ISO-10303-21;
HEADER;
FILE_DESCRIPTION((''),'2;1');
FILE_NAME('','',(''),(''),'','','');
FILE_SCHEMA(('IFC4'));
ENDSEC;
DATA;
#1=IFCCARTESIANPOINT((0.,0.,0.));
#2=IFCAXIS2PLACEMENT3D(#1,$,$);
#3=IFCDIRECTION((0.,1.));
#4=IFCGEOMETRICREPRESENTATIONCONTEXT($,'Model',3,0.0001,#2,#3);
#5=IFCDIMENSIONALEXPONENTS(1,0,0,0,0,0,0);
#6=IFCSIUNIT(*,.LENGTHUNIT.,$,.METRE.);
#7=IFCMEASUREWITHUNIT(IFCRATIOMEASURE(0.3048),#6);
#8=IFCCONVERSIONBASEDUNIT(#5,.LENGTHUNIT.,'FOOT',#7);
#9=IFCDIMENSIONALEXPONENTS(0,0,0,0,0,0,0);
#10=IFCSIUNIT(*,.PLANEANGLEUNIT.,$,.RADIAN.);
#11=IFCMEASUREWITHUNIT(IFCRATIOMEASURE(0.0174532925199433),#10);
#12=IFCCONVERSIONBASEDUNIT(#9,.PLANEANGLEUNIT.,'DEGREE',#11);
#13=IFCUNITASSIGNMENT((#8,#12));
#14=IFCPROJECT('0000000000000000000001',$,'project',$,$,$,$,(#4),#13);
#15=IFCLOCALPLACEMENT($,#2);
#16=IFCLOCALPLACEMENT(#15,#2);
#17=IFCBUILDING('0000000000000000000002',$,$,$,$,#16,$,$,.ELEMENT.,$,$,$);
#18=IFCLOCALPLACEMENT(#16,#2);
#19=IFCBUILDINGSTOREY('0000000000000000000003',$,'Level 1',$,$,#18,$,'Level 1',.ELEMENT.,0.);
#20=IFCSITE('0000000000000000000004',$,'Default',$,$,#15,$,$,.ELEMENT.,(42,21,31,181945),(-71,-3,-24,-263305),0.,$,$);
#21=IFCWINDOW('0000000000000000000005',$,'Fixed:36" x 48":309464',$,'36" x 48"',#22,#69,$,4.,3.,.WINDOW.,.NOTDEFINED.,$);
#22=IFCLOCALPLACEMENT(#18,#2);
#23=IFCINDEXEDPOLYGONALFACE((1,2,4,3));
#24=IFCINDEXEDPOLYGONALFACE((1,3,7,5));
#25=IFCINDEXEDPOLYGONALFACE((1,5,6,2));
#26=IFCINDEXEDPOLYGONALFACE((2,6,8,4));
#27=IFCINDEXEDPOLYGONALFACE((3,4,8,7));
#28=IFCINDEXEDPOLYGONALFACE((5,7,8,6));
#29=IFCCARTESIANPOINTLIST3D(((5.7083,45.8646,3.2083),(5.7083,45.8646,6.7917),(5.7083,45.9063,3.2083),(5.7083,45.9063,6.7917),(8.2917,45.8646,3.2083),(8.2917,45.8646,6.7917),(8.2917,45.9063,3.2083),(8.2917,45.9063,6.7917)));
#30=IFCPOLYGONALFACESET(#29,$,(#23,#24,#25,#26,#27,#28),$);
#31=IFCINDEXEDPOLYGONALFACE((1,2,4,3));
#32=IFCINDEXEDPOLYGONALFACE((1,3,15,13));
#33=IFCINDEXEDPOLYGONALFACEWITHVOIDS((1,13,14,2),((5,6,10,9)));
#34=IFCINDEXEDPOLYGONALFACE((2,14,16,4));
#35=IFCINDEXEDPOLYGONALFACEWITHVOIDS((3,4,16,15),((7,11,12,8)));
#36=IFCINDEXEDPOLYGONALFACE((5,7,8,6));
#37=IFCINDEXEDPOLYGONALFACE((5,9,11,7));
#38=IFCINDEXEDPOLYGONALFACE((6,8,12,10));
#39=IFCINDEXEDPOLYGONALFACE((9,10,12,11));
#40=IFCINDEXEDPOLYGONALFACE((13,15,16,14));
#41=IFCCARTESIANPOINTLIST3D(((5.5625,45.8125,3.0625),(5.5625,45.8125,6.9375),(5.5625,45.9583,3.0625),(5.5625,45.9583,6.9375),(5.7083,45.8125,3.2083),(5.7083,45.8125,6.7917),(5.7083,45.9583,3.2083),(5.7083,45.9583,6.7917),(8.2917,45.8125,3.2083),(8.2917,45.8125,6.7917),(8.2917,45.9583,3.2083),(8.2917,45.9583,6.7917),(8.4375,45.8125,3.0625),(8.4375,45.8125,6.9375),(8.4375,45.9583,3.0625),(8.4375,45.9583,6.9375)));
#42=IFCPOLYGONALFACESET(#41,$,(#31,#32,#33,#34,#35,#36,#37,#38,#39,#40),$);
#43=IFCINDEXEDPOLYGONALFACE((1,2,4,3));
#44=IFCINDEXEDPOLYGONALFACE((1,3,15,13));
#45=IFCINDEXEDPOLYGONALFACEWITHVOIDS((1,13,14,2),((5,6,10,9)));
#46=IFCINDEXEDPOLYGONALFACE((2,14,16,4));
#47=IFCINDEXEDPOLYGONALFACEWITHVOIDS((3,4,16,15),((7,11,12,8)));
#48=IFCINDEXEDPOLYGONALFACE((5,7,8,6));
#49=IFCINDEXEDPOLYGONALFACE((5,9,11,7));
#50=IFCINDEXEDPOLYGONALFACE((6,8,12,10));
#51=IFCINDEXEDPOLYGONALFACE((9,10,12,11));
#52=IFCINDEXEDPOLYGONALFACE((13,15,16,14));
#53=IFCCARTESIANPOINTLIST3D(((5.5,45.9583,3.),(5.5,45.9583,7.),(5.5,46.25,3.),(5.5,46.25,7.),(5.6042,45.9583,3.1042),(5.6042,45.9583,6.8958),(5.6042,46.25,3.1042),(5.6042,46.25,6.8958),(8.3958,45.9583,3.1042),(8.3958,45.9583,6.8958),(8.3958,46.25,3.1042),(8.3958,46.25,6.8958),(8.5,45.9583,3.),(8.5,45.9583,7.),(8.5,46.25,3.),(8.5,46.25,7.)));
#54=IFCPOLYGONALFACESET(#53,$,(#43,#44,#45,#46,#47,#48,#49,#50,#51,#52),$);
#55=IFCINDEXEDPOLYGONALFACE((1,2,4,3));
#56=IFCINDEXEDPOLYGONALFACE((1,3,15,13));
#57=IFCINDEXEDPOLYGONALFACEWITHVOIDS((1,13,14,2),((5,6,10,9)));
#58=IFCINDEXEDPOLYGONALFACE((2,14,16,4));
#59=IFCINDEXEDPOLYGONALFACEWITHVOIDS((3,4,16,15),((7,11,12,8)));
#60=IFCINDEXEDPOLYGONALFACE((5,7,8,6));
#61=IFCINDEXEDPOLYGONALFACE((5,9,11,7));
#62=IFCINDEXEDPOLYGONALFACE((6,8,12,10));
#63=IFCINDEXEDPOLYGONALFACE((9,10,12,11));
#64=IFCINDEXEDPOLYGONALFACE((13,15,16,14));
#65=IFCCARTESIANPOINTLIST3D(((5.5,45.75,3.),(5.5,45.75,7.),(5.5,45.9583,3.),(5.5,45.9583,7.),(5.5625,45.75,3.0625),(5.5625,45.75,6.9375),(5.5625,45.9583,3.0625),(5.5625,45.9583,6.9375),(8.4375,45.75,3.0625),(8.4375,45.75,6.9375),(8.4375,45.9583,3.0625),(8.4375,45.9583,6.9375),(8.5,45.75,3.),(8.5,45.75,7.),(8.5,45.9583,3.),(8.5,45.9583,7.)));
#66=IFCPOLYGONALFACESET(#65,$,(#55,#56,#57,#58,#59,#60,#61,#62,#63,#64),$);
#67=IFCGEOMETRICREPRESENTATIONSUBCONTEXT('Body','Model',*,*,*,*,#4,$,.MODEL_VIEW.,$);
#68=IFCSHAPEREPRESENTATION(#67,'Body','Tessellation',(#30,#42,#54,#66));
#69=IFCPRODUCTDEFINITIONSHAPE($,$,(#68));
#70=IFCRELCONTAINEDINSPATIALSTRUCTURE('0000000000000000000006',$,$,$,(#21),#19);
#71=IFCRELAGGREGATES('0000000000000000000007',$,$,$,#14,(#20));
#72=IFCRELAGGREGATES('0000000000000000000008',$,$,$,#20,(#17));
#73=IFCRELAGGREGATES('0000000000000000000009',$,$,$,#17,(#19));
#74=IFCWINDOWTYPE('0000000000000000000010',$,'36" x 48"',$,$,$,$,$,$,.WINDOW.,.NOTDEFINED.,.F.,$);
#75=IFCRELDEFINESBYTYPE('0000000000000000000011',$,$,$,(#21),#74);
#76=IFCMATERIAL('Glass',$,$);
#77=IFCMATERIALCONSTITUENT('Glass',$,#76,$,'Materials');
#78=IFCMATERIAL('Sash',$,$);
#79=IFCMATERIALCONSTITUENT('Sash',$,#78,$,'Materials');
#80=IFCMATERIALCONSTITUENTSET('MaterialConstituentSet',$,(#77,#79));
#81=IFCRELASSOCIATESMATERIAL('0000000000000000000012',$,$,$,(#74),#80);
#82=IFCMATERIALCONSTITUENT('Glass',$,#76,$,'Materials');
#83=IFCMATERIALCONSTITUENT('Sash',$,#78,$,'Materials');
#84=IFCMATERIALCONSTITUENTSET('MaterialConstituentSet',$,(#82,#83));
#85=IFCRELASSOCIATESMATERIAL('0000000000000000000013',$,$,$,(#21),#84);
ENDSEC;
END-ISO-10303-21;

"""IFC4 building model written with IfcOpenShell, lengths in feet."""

from ifc_helpers import new_model, entity, si_unit, converted_unit, direction, frame, frame_2d, origin, place, context, subcontext, project, spatial, polyline, rectangle, outline, extrude, source, transform, mapped, material, constituent, constituent_set, type_object, type_shapes, element, save


model = new_model("IFC4")

# Units and contexts
model_context = context("Model", 3, precision=0.0001, world=origin(), true_north=direction((0.0, 1.0)))
body_context = subcontext(model_context, "Body", "Model", "MODEL_VIEW")
ifc_project = project(units=[converted_unit("LENGTHUNIT", "FOOT", entity("IfcRatioMeasure", 0.3048), si_unit("LENGTHUNIT", "METRE"), dimensions=[1, 0, 0, 0, 0, 0, 0]), converted_unit("PLANEANGLEUNIT", "DEGREE", entity("IfcRatioMeasure", 0.0174532925199433), si_unit("PLANEANGLEUNIT", "RADIAN"), dimensions=[0, 0, 0, 0, 0, 0, 0])], contexts=[model_context])

# Site, building, storey
site_placement = place(None, origin())
site = spatial("IfcSite", under=ifc_project, at=site_placement, Name="Default", CompositionType="ELEMENT", RefLatitude=(42, 21, 31, 181945), RefLongitude=(-71, -3, -24, -263305), RefElevation=0.0)
building_placement = place(site_placement, origin())
building = spatial("IfcBuilding", under=site, at=building_placement, CompositionType="ELEMENT")
storey_placement = place(building_placement, origin())
storey = spatial("IfcBuildingStorey", under=building, at=storey_placement, Name="Level 1", LongName="Level 1", CompositionType="ELEMENT", Elevation=0.0)

# Shared definitions
placement_1 = place(storey_placement, frame((-0.25, 46.0, 0.0)))

# Window
ifc_material_1 = material(Name="Glass")
ifc_constituent_1 = constituent(ifc_material_1, Name="Glass", Category="Materials")
ifc_material_2 = material(Name="Sash")
ifc_constituent_2 = constituent(ifc_material_2, Name="Sash", Category="Materials")
ifc_constituent_set_1 = constituent_set(constituents=[ifc_constituent_1, ifc_constituent_2], Name="MaterialConstituentSet")
ifc_constituent_3 = constituent(ifc_material_1, Name="Glass", Category="Materials")
ifc_constituent_4 = constituent(ifc_material_2, Name="Sash", Category="Materials")
ifc_constituent_set_2 = constituent_set(constituents=[ifc_constituent_3, ifc_constituent_4], Name="MaterialConstituentSet")
window_type = type_object("IfcWindowType", Name="36\" x 48\"", ParameterTakesPrecedence=False, PartitioningType="NOTDEFINED", PredefinedType="WINDOW", material=ifc_constituent_set_2)
shared_shape = source(origin(), body_context, "Body", "SweptSolid", [
    extrude(rectangle(XDim=0.0417, YDim=2.5833, at=frame_2d((0.0, 0.0), x_axis=(1.0, 0.0))), frame((1.5, 0.3646, 0.2083), z_axis=(0.0, 0.0, 1.0), x_axis=(0.0, 1.0, 0.0)), (0.0, 0.0, 1.0), 3.5833),
    extrude(outline(polyline([(-1.4375, -1.9375), (1.4375, -1.9375), (1.4375, 1.9375), (-1.4375, 1.9375), (-1.4375, -1.9375)]), holes=[polyline([(-1.2917, -1.7917), (-1.2917, 1.7917), (1.2917, 1.7917), (1.2917, -1.7917), (-1.2917, -1.7917)])]), frame((1.5, 0.2917, 2.0), z_axis=(0.0, 1.0, 0.0), x_axis=(1.0, 0.0, 0.0)), (0.0, 0.0, 1.0), 0.1458),
    extrude(outline(polyline([(-1.5, -2.0), (1.5, -2.0), (1.5, 2.0), (-1.5, 2.0), (-1.5, -2.0)]), holes=[polyline([(-1.3958, -1.8958), (-1.3958, 1.8958), (1.3958, 1.8958), (1.3958, -1.8958), (-1.3958, -1.8958)])]), frame((1.5, 0.0, 2.0), z_axis=(0.0, 1.0, 0.0), x_axis=(1.0, 0.0, 0.0)), (0.0, 0.0, 1.0), 0.2917),
    extrude(outline(polyline([(-2.0, -1.5), (2.0, -1.5), (2.0, 1.5), (-2.0, 1.5), (-2.0, -1.5)]), holes=[polyline([(-1.9375, -1.4375), (-1.9375, 1.4375), (1.9375, 1.4375), (1.9375, -1.4375), (-1.9375, -1.4375)])]), frame((1.5, 0.2917, 2.0), z_axis=(0.0, 1.0, 0.0), x_axis=(0.0, 0.0, -1.0)), (0.0, 0.0, 1.0), 0.2083),
])
type_shapes(window_type, [shared_shape])
placement_2 = place(placement_1, frame((8.75, 0.25, 3.0)))
window_placement = place(placement_2, frame((0.0, 0.0, 0.0), z_axis=(0.0, 0.0, 1.0), x_axis=(-1.0, 0.0, 0.0)))
element("IfcWindow", 1, at=window_placement, inside=storey, type_object=window_type, material=ifc_constituent_set_1, Name="Fixed:36\" x 48\":309464", ObjectType="36\" x 48\"", OverallHeight=4.0, OverallWidth=3.0, PartitioningType="NOTDEFINED", PredefinedType="WINDOW", context=body_context, shape_type="MappedRepresentation", body=[
    mapped(shared_shape, transform((0.0, 0.0, 0.0), scale=1.0)),
])

save(model, "model.ifc")
